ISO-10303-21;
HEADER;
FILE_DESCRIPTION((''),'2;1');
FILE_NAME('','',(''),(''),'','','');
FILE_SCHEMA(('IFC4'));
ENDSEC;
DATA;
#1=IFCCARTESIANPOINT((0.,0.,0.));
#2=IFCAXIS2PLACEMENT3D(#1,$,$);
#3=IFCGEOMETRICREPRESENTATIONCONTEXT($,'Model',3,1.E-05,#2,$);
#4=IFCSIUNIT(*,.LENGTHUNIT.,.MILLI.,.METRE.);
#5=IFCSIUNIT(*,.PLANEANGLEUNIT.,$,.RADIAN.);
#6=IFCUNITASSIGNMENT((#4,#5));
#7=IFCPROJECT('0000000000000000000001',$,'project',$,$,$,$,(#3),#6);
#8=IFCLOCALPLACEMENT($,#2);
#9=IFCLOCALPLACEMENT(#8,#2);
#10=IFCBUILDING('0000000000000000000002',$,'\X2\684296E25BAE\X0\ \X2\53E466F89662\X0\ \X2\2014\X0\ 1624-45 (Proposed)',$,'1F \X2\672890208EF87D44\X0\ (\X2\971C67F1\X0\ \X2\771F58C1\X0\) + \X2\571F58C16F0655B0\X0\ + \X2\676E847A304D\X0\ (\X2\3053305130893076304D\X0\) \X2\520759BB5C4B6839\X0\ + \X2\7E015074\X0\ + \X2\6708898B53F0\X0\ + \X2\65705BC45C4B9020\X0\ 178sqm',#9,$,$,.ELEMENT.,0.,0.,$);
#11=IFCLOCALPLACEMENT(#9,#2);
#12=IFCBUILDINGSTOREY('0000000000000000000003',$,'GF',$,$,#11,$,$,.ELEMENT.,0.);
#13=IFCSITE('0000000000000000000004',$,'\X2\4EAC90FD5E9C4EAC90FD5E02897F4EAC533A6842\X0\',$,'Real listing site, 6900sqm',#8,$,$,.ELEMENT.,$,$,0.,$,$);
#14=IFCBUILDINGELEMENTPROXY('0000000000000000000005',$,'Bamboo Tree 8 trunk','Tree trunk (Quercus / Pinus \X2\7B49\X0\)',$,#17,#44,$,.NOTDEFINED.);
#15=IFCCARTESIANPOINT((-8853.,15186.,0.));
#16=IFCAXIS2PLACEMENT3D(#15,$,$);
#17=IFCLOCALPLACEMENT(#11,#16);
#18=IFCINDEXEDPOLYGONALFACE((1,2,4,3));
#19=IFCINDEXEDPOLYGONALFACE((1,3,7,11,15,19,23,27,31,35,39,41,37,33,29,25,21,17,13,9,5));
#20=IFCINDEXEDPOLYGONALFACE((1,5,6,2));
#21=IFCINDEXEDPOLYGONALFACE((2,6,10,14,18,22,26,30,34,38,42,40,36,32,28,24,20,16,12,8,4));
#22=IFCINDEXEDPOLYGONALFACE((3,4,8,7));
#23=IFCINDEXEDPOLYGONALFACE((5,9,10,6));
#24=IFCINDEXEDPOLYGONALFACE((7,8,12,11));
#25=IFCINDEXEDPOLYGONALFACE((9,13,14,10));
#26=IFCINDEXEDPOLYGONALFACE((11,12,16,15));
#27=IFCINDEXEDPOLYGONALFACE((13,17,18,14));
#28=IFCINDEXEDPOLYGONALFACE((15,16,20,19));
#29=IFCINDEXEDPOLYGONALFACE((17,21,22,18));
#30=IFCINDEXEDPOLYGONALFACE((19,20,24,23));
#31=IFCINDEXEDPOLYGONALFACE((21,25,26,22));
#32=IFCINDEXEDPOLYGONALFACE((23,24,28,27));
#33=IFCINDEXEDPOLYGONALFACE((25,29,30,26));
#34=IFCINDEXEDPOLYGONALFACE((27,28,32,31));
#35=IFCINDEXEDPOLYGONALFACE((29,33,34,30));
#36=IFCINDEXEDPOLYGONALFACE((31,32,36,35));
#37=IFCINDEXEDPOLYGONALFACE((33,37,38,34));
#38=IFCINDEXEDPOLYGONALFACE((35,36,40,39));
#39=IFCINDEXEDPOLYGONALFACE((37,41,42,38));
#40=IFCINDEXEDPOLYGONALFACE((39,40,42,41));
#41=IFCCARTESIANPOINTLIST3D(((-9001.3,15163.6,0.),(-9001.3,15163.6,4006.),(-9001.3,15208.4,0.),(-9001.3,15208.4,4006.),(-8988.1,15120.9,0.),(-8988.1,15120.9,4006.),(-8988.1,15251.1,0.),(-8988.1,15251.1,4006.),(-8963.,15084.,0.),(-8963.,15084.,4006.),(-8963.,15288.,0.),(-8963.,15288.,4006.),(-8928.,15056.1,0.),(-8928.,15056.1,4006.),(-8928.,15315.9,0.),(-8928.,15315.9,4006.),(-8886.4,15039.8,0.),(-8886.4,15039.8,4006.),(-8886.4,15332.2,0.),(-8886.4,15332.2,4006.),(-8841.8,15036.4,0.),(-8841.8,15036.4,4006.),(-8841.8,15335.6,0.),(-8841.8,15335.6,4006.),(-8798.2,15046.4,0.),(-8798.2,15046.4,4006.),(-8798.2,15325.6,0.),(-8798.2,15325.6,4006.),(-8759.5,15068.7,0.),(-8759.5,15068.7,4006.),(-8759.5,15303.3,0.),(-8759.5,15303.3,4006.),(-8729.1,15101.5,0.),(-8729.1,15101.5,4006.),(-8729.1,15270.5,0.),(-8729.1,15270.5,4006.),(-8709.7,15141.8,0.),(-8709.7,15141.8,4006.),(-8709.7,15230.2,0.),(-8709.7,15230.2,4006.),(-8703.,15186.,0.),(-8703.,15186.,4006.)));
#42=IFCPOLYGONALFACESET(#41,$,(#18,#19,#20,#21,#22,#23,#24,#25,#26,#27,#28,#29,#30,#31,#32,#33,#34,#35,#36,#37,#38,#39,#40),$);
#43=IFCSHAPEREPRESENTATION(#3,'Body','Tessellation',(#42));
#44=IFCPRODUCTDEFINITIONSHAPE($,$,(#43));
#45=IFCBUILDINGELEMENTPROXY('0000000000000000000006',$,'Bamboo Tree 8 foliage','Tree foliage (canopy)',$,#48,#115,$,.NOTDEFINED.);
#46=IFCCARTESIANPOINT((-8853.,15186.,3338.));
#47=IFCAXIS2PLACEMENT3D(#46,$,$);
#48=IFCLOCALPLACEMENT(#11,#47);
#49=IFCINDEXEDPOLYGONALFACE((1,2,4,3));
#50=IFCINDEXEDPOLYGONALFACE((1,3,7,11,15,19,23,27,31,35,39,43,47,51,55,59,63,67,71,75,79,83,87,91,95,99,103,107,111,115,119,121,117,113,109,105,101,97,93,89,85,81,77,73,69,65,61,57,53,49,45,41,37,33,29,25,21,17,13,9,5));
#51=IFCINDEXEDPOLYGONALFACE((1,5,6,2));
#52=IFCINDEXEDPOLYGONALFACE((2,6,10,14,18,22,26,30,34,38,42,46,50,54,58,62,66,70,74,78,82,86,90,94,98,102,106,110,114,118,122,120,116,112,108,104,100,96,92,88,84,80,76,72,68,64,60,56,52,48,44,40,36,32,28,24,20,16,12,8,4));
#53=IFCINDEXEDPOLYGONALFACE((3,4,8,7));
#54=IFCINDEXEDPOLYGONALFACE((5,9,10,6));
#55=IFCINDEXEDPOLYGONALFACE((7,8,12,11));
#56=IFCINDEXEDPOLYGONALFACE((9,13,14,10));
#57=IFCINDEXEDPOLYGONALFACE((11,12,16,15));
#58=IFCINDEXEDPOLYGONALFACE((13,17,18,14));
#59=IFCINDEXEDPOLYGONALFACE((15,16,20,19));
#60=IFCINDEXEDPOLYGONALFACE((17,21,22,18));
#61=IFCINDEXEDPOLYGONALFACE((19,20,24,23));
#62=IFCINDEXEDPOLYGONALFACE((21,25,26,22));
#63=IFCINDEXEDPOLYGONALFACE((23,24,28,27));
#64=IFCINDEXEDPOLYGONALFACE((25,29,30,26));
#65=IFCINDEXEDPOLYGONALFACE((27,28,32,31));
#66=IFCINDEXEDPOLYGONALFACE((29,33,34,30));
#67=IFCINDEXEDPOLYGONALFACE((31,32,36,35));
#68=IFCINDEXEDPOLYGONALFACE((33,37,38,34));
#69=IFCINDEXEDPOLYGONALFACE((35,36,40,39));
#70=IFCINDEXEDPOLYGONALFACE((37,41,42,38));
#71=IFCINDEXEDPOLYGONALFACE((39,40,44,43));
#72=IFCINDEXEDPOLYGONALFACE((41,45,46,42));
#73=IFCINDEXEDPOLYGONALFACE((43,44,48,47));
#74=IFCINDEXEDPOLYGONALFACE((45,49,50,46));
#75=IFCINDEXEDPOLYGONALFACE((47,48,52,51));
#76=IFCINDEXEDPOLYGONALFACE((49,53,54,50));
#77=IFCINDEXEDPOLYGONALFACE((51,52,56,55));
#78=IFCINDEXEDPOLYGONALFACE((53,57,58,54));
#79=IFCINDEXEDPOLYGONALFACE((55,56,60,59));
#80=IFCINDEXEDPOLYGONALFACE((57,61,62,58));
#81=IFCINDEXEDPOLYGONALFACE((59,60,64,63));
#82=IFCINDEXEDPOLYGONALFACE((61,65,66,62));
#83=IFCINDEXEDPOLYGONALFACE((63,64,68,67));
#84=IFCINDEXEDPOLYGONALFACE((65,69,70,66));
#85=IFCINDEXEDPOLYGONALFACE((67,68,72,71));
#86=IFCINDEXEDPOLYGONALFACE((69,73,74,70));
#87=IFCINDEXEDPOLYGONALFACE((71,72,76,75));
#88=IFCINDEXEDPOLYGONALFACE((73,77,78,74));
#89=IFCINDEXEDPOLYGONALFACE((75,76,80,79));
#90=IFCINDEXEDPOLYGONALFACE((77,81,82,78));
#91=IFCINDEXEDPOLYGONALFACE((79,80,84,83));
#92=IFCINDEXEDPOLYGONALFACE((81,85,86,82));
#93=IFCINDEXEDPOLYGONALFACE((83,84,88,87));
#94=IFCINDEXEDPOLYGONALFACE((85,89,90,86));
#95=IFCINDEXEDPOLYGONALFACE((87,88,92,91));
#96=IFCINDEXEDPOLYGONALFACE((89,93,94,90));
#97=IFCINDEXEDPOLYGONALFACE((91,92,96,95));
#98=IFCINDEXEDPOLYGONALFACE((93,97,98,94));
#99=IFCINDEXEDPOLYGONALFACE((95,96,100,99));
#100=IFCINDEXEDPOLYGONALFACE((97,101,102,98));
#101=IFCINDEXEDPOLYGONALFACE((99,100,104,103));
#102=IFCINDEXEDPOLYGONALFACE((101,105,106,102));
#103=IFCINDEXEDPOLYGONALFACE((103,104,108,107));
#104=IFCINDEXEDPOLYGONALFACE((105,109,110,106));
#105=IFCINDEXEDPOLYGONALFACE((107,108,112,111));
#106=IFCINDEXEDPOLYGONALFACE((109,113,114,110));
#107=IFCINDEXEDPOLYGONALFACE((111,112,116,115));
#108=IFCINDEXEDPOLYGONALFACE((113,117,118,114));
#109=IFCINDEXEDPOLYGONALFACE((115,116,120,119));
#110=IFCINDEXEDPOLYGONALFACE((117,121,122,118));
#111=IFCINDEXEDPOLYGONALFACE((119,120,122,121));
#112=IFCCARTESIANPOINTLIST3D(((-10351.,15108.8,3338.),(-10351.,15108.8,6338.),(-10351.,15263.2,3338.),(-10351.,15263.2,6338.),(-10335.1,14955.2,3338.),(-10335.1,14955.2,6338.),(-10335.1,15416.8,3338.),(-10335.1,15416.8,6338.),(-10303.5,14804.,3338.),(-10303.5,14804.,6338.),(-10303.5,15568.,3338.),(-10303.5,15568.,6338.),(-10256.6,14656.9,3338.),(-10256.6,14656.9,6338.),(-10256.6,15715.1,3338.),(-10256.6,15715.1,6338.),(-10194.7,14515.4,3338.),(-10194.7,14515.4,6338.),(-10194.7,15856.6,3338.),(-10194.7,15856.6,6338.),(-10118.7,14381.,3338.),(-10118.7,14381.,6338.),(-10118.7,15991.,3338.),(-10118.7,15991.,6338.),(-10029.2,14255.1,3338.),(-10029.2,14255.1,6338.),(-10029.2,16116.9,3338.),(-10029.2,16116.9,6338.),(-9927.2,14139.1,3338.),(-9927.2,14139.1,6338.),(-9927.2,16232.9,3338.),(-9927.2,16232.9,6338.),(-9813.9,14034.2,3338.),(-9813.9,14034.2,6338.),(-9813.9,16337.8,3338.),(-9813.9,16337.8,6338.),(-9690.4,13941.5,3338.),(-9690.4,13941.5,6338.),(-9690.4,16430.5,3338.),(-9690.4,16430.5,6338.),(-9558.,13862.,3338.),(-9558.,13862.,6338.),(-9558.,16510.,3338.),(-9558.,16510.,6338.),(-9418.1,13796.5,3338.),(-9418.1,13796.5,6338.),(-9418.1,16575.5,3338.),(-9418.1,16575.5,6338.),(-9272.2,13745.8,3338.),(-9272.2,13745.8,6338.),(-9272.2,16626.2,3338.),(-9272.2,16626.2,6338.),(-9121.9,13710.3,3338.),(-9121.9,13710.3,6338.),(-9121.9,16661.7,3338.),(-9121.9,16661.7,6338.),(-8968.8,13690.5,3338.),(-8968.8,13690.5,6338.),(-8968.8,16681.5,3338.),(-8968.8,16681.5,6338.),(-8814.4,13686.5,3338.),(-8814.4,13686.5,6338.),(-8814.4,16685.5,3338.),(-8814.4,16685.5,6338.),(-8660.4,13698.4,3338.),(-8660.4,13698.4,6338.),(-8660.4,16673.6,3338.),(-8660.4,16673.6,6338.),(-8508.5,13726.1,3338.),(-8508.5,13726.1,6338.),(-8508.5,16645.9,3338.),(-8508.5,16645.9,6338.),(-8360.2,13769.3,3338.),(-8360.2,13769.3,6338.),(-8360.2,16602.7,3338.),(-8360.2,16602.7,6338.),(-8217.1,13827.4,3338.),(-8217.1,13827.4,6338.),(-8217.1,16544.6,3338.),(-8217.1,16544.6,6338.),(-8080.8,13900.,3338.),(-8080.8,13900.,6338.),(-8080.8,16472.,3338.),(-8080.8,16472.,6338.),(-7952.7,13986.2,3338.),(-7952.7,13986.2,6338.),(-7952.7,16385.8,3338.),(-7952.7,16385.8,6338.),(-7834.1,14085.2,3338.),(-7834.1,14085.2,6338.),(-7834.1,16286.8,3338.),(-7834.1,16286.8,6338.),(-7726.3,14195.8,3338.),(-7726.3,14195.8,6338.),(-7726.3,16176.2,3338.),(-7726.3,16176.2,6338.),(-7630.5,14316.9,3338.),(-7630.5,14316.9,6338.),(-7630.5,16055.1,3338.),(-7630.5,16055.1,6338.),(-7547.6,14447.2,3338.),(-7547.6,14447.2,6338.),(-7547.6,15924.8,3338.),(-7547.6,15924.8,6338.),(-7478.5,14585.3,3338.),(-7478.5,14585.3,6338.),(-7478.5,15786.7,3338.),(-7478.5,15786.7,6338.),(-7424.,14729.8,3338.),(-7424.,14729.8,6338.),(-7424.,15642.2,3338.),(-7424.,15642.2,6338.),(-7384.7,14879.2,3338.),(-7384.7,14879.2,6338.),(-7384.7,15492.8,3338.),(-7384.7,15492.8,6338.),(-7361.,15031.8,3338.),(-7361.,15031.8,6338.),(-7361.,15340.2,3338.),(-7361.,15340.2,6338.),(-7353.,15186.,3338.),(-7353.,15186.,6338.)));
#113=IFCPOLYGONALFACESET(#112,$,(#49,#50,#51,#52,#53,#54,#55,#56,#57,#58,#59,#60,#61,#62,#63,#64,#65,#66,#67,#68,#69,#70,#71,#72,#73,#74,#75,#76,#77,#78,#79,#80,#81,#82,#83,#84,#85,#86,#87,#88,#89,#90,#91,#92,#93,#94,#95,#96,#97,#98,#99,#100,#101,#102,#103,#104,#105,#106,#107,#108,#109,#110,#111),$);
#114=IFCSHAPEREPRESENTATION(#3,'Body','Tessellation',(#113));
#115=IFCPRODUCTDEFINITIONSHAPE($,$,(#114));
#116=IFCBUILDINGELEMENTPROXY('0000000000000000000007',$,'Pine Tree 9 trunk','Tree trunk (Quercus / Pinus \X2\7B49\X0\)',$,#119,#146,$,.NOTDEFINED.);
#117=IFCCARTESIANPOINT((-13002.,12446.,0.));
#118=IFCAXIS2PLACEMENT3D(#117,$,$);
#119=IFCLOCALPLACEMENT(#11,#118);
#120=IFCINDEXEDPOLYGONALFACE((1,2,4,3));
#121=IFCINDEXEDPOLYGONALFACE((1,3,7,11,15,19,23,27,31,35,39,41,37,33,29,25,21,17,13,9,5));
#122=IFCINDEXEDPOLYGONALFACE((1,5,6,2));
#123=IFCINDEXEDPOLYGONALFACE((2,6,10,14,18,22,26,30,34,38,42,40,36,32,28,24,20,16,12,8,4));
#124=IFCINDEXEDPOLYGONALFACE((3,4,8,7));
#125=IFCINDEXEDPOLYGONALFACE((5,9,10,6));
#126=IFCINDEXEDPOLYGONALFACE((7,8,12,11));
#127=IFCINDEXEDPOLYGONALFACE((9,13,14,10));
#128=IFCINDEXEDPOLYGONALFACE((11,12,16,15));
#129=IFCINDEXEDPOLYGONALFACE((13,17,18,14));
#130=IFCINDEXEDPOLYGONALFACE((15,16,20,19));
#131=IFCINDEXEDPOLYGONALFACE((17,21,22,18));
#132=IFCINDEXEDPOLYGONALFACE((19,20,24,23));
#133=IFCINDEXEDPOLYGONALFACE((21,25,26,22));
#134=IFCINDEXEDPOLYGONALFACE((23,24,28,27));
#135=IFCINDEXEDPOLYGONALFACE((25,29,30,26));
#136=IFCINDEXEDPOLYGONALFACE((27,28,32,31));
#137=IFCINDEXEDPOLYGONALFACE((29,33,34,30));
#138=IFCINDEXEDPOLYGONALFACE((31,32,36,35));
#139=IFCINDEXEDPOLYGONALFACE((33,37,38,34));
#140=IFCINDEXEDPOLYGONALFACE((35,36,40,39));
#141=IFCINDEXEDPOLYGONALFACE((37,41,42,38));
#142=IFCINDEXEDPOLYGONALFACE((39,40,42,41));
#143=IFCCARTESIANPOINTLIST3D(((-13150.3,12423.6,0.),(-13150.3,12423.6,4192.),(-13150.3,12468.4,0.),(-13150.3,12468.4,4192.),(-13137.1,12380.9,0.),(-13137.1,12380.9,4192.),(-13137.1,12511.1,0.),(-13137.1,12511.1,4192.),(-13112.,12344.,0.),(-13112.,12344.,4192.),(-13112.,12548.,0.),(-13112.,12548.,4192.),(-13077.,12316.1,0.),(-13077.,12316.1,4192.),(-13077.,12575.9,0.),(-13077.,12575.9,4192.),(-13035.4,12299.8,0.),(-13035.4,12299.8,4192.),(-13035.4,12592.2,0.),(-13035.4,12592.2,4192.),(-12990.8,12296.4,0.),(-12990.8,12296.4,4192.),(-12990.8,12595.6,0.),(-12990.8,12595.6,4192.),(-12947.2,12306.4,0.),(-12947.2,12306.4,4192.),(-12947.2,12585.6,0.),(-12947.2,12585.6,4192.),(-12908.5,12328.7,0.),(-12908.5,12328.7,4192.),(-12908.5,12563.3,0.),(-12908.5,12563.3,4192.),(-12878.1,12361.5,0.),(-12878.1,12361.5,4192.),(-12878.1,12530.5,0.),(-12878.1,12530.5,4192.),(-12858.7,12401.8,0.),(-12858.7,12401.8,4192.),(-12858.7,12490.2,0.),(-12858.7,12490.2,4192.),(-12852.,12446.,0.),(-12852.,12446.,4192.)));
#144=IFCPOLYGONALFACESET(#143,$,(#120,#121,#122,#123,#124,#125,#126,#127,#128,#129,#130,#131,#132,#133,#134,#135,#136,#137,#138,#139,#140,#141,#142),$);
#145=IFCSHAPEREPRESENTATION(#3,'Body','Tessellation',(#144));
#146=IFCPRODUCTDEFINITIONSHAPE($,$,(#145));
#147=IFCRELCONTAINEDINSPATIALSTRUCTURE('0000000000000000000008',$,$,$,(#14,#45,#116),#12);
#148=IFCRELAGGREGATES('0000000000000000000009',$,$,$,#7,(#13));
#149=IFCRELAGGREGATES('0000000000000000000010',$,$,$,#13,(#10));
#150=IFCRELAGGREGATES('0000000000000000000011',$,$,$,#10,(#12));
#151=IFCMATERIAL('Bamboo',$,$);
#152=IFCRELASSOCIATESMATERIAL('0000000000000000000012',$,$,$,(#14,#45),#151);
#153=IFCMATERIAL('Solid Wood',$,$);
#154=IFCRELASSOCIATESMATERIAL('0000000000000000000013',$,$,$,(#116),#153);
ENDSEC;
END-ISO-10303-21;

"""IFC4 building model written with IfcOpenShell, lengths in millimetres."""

from ifc_helpers import new_model, si_unit, frame, origin, origin_2d, place, context, project, spatial, circle, extrude, material, element, save


model = new_model("IFC4")

# Units and contexts
model_context = context("Model", 3, precision=1e-05, world=origin())
ifc_project = project(units=[si_unit("LENGTHUNIT", "METRE", prefix="MILLI"), si_unit("PLANEANGLEUNIT", "RADIAN")], contexts=[model_context])

# Site, building, storey
site_placement = place(None, origin())
site = spatial("IfcSite", under=ifc_project, at=site_placement, Name="京都府京都市西京区桂", ObjectType="Real listing site, 6900sqm", CompositionType="ELEMENT", RefElevation=0.0)
building_placement = place(site_placement, origin())
building = spatial("IfcBuilding", under=site, at=building_placement, Name="桂離宮 古書院 — 1624-45 (Proposed)", ObjectType="1F 木造軸組 (霜柱 真壁) + 土壁漆喰 + 杮葺き (こけらぶき) 切妻屋根 + 縁側 + 月見台 + 数寄屋造 178sqm", CompositionType="ELEMENT", ElevationOfRefHeight=0.0, ElevationOfTerrain=0.0)
storey_placement = place(building_placement, origin())
storey = spatial("IfcBuildingStorey", under=building, at=storey_placement, Name="GF", CompositionType="ELEMENT", Elevation=0.0)

# Shared definitions
ifc_material_1 = material(Name="Solid Wood")

# Building element proxies
ifc_material_2 = material(Name="Bamboo")
proxy_1_placement = place(storey_placement, frame((-8853.0, 15186.0, 0.0)))
element("IfcBuildingElementProxy", 1, at=proxy_1_placement, inside=storey, material=ifc_material_2, Name="Bamboo Tree 8 trunk", Description="Tree trunk (Quercus / Pinus 等)", PredefinedType="NOTDEFINED", context=model_context, shape_type="SweptSolid", body=[
    extrude(circle(Radius=150.0, at=origin_2d()), frame((-8853.0, 15186.0, 0.0)), (0.0, 0.0, 1.0), 4006.0),
])
proxy_2_placement = place(storey_placement, frame((-8853.0, 15186.0, 3338.0)))
element("IfcBuildingElementProxy", 2, at=proxy_2_placement, inside=storey, material=ifc_material_2, Name="Bamboo Tree 8 foliage", Description="Tree foliage (canopy)", PredefinedType="NOTDEFINED", context=model_context, shape_type="SweptSolid", body=[
    extrude(circle(Radius=1500.0, at=origin_2d()), frame((-8853.0, 15186.0, 3338.0)), (0.0, 0.0, 1.0), 3000.0),
])
proxy_3_placement = place(storey_placement, frame((-13002.0, 12446.0, 0.0)))
element("IfcBuildingElementProxy", 3, at=proxy_3_placement, inside=storey, material=ifc_material_1, Name="Pine Tree 9 trunk", Description="Tree trunk (Quercus / Pinus 等)", PredefinedType="NOTDEFINED", context=model_context, shape_type="SweptSolid", body=[
    extrude(circle(Radius=150.0, at=origin_2d()), frame((-13002.0, 12446.0, 0.0)), (0.0, 0.0, 1.0), 4192.0),
])

save(model, "model.ifc")
